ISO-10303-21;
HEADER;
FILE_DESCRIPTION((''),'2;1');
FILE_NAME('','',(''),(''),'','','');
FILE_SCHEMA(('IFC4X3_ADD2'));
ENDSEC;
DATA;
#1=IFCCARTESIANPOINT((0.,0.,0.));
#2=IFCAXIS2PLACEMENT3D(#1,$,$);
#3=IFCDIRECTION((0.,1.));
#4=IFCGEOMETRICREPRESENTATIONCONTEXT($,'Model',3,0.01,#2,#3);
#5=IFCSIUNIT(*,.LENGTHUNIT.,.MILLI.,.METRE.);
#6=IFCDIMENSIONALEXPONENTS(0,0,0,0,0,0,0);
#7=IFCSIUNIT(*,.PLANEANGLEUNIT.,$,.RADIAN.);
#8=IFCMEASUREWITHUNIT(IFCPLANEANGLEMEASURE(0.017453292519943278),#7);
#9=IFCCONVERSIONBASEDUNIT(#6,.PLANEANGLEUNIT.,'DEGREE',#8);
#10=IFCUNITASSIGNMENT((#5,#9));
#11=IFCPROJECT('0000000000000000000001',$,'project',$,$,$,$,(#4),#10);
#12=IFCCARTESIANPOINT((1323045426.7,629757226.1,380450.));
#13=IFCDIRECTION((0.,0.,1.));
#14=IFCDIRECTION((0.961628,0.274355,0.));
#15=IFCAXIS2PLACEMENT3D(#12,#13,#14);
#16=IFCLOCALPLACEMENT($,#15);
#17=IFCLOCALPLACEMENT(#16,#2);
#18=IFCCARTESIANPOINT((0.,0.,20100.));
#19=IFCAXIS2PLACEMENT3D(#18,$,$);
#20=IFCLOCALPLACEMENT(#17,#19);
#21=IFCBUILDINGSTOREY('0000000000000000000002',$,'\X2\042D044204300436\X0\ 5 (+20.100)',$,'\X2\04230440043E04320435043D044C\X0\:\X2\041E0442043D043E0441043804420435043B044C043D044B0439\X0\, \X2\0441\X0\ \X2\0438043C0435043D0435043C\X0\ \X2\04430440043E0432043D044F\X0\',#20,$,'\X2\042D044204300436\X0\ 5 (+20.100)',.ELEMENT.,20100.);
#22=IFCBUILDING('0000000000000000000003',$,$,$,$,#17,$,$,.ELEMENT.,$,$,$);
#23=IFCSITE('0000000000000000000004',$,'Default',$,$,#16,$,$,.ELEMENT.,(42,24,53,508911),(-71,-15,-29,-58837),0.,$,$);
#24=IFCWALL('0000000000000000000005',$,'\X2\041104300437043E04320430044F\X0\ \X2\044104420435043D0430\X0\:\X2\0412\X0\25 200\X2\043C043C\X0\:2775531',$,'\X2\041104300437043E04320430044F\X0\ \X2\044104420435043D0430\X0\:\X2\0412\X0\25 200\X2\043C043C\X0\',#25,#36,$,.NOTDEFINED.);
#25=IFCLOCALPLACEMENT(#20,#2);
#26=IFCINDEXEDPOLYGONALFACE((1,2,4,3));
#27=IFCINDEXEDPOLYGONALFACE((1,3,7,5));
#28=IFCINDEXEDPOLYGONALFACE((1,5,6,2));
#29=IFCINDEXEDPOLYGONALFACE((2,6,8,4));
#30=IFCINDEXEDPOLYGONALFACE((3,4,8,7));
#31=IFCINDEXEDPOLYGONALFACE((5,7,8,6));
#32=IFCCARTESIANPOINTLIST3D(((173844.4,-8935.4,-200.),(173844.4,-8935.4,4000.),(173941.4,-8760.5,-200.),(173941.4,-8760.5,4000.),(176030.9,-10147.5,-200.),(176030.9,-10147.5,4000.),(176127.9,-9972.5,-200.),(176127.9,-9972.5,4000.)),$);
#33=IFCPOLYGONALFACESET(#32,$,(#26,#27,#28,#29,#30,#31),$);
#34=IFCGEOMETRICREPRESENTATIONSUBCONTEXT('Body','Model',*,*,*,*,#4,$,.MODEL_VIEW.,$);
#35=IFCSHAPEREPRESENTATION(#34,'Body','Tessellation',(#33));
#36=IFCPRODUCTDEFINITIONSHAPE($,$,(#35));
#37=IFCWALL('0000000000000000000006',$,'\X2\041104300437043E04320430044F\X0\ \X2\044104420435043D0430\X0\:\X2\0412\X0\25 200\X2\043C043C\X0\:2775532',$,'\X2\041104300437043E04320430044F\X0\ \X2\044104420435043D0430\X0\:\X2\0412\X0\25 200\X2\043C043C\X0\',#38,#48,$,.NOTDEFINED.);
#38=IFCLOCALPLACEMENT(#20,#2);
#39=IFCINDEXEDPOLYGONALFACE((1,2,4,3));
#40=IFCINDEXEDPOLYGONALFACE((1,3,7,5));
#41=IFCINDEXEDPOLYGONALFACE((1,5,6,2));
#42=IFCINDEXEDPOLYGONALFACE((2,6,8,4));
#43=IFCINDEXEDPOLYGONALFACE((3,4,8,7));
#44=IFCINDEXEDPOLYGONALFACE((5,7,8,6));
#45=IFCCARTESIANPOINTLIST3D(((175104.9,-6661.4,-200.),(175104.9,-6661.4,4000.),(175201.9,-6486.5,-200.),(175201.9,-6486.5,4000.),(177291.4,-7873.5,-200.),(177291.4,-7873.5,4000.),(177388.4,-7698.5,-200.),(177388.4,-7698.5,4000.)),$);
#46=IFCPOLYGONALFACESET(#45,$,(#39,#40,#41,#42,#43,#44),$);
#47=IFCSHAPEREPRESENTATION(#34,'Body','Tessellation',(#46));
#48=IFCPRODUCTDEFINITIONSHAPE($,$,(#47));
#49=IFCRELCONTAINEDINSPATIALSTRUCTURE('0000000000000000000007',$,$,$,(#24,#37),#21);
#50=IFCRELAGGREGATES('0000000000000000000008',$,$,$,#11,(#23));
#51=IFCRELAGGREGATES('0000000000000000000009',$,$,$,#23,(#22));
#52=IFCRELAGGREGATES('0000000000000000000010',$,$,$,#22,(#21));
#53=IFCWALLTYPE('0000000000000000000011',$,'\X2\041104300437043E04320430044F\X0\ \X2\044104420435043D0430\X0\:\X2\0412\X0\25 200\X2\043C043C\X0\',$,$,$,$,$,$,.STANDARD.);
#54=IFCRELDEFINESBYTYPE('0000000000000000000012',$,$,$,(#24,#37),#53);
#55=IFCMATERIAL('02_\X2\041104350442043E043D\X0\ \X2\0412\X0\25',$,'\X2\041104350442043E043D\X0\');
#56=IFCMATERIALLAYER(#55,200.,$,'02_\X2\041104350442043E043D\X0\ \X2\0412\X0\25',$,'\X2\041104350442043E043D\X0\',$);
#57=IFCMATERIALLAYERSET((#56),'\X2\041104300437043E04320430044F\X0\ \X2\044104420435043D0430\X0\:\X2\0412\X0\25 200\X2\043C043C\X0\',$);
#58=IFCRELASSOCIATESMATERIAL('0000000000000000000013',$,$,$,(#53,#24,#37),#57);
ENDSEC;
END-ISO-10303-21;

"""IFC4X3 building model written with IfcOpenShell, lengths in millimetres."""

from ifc_helpers import new_model, entity, si_unit, converted_unit, direction, frame, frame_2d, origin, place, context, subcontext, project, spatial, rectangle, extrude, material, layer, layer_set, type_object, element, save


model = new_model("IFC4X3")

# Units and contexts
model_context = context("Model", 3, precision=0.01, world=origin(), true_north=direction((0.0, 1.0)))
body_context = subcontext(model_context, "Body", "Model", "MODEL_VIEW")
ifc_project = project(units=[si_unit("LENGTHUNIT", "METRE", prefix="MILLI"), converted_unit("PLANEANGLEUNIT", "DEGREE", entity("IfcPlaneAngleMeasure", 0.017453292519943278), si_unit("PLANEANGLEUNIT", "RADIAN"), dimensions=[0, 0, 0, 0, 0, 0, 0])], contexts=[model_context])

# Site, building, storey
site_placement = place(None, frame((1323045426.7, 629757226.1, 380450.0), z_axis=(0.0, 0.0, 1.0), x_axis=(0.961628, 0.274355, 0.0)))
site = spatial("IfcSite", under=ifc_project, at=site_placement, Name="Default", CompositionType="ELEMENT", RefLatitude=(42, 24, 53, 508911), RefLongitude=(-71, -15, -29, -58837), RefElevation=0.0)
building_placement = place(site_placement, origin())
building = spatial("IfcBuilding", under=site, at=building_placement, CompositionType="ELEMENT")
storey_placement = place(building_placement, frame((0.0, 0.0, 20100.0)))
storey = spatial("IfcBuildingStorey", under=building, at=storey_placement, Name="Этаж 5 (+20.100)", ObjectType="Уровень:Относительный, с именем уровня", LongName="Этаж 5 (+20.100)", CompositionType="ELEMENT", Elevation=20100.0)

# Walls
ifc_material_1 = material(Name="02_Бетон В25", Category="Бетон")
ifc_layer_1 = layer(ifc_material_1, 200.0, Name="02_Бетон В25", Category="Бетон")
ifc_layer_set_1 = layer_set([ifc_layer_1], Name="Базовая стена:В25 200мм")
wall_type_1 = type_object("IfcWallType", Name="Базовая стена:В25 200мм", PredefinedType="STANDARD", material=ifc_layer_set_1)
wall_1_placement = place(storey_placement, frame((173892.9, -8848.0, -200.0), z_axis=(0.0, 0.0, 1.0), x_axis=(0.87462, -0.48481, 0.0)))
element("IfcWall", 1, at=wall_1_placement, inside=storey, type_object=wall_type_1, material=ifc_layer_set_1, Name="Базовая стена:В25 200мм:2775531", ObjectType="Базовая стена:В25 200мм", PredefinedType="NOTDEFINED", context=body_context, shape_type="SweptSolid", body=[
    extrude(rectangle(XDim=2500.0, YDim=200.0, at=frame_2d((1250.0, 0.0), x_axis=(-1.0, 0.0))), origin(), (0.0, 0.0, 1.0), 4200.0),
])
wall_2_placement = place(storey_placement, frame((175153.4, -6574.0, -200.0), z_axis=(0.0, 0.0, 1.0), x_axis=(0.87462, -0.48481, 0.0)))
element("IfcWall", 2, at=wall_2_placement, inside=storey, type_object=wall_type_1, material=ifc_layer_set_1, Name="Базовая стена:В25 200мм:2775532", ObjectType="Базовая стена:В25 200мм", PredefinedType="NOTDEFINED", context=body_context, shape_type="SweptSolid", body=[
    extrude(rectangle(XDim=2500.0, YDim=200.0, at=frame_2d((1250.0, 0.0), x_axis=(-1.0, 0.0))), origin(), (0.0, 0.0, 1.0), 4200.0),
])

save(model, "model.ifc")
